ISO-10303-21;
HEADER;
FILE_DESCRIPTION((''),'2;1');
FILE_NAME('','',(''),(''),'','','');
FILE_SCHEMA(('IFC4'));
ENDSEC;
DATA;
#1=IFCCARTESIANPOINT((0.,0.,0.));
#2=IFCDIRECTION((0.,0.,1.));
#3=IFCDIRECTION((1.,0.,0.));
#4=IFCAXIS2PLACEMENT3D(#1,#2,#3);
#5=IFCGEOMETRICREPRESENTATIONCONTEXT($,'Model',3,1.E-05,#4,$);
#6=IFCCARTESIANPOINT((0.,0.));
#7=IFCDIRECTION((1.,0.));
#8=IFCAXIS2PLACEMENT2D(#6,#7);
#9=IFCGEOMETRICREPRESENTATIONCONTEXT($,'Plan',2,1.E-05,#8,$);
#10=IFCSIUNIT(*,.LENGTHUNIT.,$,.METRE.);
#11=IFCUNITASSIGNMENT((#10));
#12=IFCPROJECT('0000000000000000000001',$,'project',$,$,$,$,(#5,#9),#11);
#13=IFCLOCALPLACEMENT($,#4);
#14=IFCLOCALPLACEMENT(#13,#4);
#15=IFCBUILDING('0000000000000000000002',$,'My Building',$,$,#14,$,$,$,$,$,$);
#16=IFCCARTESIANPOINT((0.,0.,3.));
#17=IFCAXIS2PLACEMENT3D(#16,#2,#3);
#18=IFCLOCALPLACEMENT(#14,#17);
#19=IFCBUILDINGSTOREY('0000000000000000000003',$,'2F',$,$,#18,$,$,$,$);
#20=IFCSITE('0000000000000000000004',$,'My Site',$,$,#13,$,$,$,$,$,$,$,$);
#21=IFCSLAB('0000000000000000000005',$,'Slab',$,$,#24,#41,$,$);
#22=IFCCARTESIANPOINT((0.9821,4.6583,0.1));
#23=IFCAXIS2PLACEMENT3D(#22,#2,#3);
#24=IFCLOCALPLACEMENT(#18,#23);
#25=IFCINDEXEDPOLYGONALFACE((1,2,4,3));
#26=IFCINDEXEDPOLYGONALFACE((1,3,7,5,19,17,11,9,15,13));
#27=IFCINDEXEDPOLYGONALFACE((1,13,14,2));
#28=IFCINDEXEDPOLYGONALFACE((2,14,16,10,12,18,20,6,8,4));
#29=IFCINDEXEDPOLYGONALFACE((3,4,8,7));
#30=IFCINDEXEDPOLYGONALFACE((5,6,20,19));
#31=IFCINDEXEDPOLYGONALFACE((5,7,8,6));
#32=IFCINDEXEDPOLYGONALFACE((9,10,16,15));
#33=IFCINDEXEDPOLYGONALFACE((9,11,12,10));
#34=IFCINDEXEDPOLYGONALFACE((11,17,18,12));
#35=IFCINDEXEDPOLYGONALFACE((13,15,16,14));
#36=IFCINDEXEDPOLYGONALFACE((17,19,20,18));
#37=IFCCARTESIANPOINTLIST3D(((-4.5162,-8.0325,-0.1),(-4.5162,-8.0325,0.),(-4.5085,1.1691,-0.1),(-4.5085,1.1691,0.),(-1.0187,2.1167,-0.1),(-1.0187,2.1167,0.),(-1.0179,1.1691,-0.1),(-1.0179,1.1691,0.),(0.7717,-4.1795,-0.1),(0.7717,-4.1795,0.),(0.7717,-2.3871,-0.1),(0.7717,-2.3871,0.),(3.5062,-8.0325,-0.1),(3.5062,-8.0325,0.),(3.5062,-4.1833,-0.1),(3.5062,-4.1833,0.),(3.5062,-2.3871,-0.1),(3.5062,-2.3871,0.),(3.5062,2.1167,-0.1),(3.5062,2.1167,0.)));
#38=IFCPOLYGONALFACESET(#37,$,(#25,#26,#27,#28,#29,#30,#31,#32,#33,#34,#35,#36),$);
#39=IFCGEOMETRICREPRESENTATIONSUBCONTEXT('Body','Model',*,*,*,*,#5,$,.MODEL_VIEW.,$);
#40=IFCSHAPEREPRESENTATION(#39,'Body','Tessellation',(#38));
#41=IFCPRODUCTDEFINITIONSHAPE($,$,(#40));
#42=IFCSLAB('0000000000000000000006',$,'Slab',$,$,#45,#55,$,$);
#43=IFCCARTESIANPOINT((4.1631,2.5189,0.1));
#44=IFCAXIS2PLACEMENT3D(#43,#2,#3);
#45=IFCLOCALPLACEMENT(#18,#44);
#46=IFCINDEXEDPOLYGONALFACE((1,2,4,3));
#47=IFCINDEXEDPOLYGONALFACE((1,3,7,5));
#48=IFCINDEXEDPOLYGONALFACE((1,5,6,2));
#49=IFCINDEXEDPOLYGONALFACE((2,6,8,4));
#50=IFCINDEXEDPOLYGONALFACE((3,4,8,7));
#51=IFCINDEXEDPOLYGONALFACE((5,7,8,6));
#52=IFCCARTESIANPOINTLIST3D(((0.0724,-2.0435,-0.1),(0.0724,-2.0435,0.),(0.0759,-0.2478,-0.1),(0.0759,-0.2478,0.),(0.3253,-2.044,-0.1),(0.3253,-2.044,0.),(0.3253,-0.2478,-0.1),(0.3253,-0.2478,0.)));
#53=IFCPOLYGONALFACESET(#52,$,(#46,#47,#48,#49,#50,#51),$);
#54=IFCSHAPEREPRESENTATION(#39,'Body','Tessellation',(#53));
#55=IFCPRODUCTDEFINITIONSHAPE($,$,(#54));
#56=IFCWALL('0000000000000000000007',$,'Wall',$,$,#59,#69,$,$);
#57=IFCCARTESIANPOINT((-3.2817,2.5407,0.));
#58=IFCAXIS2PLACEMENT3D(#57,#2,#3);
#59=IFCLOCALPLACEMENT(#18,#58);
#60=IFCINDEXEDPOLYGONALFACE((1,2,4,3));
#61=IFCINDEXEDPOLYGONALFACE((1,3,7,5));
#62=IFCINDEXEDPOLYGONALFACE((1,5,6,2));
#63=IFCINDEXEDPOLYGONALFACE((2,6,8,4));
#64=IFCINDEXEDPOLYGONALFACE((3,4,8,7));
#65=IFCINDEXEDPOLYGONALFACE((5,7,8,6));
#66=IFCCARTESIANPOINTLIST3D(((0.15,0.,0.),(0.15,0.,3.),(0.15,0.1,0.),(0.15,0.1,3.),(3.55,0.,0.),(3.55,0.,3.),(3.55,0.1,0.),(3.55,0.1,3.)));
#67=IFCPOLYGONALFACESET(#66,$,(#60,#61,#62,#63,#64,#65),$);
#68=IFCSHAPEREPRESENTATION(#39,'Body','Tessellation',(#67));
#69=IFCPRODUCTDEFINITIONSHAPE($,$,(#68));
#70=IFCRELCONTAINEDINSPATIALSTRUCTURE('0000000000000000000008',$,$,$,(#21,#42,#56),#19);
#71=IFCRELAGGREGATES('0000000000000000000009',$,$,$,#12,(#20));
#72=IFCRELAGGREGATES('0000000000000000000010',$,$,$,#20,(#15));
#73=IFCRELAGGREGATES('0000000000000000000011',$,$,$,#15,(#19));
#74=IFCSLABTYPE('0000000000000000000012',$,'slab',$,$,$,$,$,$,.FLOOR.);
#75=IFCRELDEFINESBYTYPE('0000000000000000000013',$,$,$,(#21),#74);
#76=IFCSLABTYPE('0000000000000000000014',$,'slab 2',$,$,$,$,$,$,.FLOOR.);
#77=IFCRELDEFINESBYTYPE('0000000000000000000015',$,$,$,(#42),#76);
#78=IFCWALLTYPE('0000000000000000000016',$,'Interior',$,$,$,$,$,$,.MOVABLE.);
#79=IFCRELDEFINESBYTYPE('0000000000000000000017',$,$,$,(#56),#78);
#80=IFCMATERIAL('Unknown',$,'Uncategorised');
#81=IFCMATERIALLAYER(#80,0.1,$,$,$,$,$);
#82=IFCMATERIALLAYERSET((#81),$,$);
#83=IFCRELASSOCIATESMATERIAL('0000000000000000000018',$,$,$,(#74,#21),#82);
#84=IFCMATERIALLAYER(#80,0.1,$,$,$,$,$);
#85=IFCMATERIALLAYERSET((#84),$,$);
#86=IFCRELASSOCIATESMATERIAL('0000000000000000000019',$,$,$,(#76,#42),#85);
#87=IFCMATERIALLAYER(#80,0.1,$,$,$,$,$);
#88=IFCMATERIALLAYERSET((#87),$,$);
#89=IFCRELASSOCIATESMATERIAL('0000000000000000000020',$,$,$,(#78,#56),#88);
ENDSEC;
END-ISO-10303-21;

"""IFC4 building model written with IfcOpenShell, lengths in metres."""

from ifc_helpers import new_model, si_unit, frame, origin_with_axes, origin_2d_with_axis, place, context, subcontext, project, spatial, line, indexed_curve, outline, extrude, material, layer, layer_set, layer_usage, type_object, element, save


model = new_model("IFC4")

# Units and contexts
model_context = context("Model", 3, precision=1e-05, world=origin_with_axes())
plan_context = context("Plan", 2, precision=1e-05, world=origin_2d_with_axis())
body_context_1 = subcontext(model_context, "Body", "Model", "MODEL_VIEW")
ifc_project = project(units=[si_unit("LENGTHUNIT", "METRE")], contexts=[model_context, plan_context])

# Site, building, storey
site_placement = place(None, origin_with_axes())
site = spatial("IfcSite", under=ifc_project, at=site_placement, Name="My Site")
building_placement = place(site_placement, origin_with_axes())
building = spatial("IfcBuilding", under=site, at=building_placement, Name="My Building")
storey_placement = place(building_placement, frame((0.0, 0.0, 3.0), z_axis=(0.0, 0.0, 1.0), x_axis=(1.0, 0.0, 0.0)))
storey = spatial("IfcBuildingStorey", under=building, at=storey_placement, Name="2F")

# Slabs
ifc_material = material(Name="Unknown", Category="Uncategorised")
ifc_layer_1 = layer(ifc_material, 0.1)
ifc_layer_set_1 = layer_set([ifc_layer_1])
ifc_layer_usage_1 = layer_usage(ifc_layer_set_1, "AXIS3", "POSITIVE", -0.1)
slab_type_1 = type_object("IfcSlabType", Name="slab", PredefinedType="FLOOR", material=ifc_layer_set_1)
slab_1_placement = place(storey_placement, frame((0.9821, 4.6583, 0.1), z_axis=(0.0, 0.0, 1.0), x_axis=(1.0, 0.0, 0.0)))
element("IfcSlab", 1, at=slab_1_placement, inside=storey, type_object=slab_type_1, material=ifc_layer_usage_1, Name="Slab", context=body_context_1, shape_type="SweptSolid", body=[
    extrude(outline(indexed_curve([(-1.0187, 2.1167), (-1.0179, 1.1691), (-4.5085, 1.1691), (-4.5162, -8.0325), (3.5062, -8.0325), (3.5062, -4.1833), (0.7717, -4.1795), (0.7717, -2.3871), (3.5062, -2.3871), (3.5062, 2.1167), (-1.0187, 2.1167)])), frame((0.0, 0.0, -0.1), z_axis=(0.0, 0.0, 1.0), x_axis=(1.0, 0.0, 0.0)), (0.0, 0.0, 1.0), 0.1),
])
ifc_layer_2 = layer(ifc_material, 0.1)
ifc_layer_set_2 = layer_set([ifc_layer_2])
ifc_layer_usage_2 = layer_usage(ifc_layer_set_2, "AXIS3", "POSITIVE", -0.1)
slab_type_2 = type_object("IfcSlabType", Name="slab 2", PredefinedType="FLOOR", material=ifc_layer_set_2)
slab_2_placement = place(storey_placement, frame((4.1631, 2.5189, 0.1), z_axis=(0.0, 0.0, 1.0), x_axis=(1.0, 0.0, 0.0)))
element("IfcSlab", 2, at=slab_2_placement, inside=storey, type_object=slab_type_2, material=ifc_layer_usage_2, Name="Slab", context=body_context_1, shape_type="SweptSolid", body=[
    extrude(outline(indexed_curve([(0.0724, -2.0435), (0.3253, -2.044), (0.3253, -0.2478), (0.0759, -0.2478), (0.0724, -2.0435)])), frame((0.0, 0.0, -0.1), z_axis=(0.0, 0.0, 1.0), x_axis=(1.0, 0.0, 0.0)), (0.0, 0.0, 1.0), 0.1),
])

# Shared definitions
ifc_layer_3 = layer(ifc_material, 0.1)
ifc_layer_set_3 = layer_set([ifc_layer_3])
wall_type_1 = type_object("IfcWallType", Name="Interior", PredefinedType="MOVABLE", material=ifc_layer_set_3)

# Wall
ifc_layer_usage_3 = layer_usage(ifc_layer_set_3, "AXIS2", "POSITIVE", 0.0)
wall_1_placement = place(storey_placement, frame((-3.2817, 2.5407, 0.0), z_axis=(0.0, 0.0, 1.0), x_axis=(1.0, 0.0, 0.0)))
element("IfcWall", 3, at=wall_1_placement, inside=storey, type_object=wall_type_1, material=ifc_layer_usage_3, Name="Wall", context=body_context_1, shape_type="SweptSolid", body=[
    extrude(outline(indexed_curve([(0.15, 0.0), (0.15, 0.1), (3.55, 0.1), (3.55, 0.0)], segments=[line(1, 2, 3, 4, 1)])), origin_with_axes(), (0.0, 0.0, 1.0), 3.0),
])

save(model, "model.ifc")
